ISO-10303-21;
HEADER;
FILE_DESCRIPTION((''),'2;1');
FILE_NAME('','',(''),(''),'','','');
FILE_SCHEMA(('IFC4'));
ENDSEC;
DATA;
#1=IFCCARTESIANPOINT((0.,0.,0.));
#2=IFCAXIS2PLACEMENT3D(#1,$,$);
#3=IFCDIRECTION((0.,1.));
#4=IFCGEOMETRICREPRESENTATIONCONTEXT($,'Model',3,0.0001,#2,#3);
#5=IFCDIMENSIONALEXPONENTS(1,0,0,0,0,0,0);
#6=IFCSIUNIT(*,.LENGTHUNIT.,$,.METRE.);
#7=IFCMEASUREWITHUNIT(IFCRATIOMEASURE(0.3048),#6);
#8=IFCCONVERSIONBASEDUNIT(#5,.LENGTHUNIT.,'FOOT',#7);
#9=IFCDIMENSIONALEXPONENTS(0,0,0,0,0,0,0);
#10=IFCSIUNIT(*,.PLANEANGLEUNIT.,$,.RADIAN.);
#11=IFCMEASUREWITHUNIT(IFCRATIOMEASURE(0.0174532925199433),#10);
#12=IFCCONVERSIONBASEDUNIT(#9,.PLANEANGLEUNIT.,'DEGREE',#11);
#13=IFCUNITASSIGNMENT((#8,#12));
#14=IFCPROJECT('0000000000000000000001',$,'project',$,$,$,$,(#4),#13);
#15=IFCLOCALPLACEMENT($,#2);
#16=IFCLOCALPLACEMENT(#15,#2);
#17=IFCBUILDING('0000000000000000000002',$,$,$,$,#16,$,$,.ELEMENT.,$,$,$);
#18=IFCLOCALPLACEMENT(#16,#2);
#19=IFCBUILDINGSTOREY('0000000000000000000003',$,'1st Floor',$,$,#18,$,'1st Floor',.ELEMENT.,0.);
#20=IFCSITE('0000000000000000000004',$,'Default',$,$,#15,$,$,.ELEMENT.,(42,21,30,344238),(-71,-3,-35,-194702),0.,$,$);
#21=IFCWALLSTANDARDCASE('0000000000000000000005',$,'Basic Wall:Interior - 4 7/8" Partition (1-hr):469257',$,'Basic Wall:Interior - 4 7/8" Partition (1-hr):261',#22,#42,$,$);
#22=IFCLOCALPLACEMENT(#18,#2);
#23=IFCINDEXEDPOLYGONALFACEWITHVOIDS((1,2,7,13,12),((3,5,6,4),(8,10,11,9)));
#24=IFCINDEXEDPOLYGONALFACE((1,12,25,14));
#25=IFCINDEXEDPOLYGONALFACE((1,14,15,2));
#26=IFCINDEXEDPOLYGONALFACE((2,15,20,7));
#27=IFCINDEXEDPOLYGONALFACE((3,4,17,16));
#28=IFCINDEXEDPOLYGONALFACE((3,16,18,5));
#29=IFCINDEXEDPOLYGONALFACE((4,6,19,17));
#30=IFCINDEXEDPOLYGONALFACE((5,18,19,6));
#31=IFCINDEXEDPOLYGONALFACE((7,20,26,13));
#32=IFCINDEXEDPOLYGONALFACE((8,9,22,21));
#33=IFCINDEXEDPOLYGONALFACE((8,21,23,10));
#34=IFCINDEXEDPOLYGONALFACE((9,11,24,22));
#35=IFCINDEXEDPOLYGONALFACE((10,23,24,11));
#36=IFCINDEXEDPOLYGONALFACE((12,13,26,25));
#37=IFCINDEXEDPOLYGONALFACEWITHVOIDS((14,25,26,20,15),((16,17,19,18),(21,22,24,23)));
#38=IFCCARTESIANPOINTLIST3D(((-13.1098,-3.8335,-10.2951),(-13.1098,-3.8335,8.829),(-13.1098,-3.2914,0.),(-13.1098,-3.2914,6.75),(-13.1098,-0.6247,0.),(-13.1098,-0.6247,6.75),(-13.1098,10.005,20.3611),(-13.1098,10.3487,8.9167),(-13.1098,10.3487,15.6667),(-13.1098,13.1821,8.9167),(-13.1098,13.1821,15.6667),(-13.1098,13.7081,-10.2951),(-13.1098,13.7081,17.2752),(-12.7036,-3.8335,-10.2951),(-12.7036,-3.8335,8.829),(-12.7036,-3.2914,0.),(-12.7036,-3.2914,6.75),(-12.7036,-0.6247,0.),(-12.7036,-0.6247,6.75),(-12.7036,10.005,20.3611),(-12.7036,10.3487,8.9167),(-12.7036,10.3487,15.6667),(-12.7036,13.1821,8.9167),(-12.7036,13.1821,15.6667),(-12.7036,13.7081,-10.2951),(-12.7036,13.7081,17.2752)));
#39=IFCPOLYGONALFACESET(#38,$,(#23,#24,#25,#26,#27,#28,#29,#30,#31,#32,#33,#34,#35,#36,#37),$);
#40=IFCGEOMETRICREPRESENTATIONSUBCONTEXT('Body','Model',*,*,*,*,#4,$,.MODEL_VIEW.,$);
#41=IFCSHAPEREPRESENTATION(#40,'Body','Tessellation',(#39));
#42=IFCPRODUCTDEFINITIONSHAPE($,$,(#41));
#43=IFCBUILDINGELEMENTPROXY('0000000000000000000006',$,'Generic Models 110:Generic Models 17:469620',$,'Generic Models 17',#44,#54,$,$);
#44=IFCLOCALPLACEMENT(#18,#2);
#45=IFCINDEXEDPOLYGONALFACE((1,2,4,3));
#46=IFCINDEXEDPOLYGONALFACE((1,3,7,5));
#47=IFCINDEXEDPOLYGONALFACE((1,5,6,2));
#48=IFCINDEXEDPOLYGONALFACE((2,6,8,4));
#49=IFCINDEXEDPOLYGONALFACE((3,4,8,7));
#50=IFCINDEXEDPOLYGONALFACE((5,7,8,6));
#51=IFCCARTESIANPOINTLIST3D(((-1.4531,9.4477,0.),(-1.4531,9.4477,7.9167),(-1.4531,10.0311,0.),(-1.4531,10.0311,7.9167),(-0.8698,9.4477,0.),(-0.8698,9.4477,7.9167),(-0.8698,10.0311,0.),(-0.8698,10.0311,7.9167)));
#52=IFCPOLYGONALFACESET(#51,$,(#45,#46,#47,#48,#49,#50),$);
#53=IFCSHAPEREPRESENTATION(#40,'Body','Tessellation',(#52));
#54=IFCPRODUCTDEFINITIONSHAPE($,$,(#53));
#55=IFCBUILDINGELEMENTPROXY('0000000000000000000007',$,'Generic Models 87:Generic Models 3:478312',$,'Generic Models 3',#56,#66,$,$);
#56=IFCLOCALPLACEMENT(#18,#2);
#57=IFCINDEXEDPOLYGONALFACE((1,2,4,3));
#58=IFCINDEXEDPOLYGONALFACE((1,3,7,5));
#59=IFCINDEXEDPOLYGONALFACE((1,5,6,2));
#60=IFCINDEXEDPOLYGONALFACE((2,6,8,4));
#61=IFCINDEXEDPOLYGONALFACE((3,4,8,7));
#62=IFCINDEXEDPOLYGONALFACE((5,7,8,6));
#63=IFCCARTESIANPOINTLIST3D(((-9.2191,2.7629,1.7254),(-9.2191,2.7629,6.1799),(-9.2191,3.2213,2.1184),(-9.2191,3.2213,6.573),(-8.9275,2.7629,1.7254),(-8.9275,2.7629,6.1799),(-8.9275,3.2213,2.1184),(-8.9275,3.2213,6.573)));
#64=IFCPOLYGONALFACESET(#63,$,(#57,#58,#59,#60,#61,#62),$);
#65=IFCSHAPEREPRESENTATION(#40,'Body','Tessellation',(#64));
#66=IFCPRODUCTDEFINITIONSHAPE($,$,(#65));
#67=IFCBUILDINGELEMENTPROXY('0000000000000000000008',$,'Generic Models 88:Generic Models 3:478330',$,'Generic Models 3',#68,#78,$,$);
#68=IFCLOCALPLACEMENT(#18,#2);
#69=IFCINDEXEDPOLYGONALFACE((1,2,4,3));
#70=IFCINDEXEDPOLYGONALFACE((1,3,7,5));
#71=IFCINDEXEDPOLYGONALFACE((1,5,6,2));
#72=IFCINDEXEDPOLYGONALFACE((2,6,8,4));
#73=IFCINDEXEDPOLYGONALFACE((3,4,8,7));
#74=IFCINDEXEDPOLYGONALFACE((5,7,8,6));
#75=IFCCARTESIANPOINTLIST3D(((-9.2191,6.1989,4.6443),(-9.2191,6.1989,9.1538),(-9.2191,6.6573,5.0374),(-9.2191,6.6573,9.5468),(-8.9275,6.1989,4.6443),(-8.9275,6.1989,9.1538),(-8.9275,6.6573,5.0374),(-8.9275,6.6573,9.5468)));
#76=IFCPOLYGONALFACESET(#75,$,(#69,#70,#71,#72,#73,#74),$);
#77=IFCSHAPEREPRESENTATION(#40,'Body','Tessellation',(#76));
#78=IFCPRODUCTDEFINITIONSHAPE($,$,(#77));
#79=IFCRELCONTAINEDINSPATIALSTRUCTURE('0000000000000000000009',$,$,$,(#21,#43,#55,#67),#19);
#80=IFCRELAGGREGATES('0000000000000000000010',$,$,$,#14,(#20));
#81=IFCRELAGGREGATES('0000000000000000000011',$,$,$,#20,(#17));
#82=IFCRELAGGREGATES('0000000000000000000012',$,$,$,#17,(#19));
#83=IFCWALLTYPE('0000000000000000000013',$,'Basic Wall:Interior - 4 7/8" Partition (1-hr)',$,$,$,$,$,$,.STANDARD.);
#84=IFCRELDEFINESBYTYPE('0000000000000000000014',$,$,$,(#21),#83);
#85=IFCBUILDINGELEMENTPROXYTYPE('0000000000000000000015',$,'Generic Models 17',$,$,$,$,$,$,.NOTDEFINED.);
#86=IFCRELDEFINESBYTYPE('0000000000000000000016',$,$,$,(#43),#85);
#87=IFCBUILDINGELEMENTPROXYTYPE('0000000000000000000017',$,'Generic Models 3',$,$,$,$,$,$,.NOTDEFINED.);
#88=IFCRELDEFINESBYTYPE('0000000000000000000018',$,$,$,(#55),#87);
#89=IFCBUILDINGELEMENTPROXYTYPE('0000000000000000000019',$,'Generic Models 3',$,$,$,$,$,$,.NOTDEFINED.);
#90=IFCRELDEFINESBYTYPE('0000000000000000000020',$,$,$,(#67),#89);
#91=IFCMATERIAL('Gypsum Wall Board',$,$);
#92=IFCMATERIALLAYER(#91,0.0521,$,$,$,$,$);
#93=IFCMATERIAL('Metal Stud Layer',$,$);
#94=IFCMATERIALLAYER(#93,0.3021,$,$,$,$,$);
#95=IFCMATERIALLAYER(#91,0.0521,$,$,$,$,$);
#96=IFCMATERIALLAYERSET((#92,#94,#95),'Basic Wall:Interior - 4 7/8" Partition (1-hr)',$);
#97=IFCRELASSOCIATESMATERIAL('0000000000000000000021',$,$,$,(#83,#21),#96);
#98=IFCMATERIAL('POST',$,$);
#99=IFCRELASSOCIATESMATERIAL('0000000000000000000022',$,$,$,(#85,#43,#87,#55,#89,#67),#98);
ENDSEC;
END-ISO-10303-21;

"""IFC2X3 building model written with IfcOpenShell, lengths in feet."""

from ifc_helpers import new_model, entity, si_unit, converted_unit, direction, frame, frame_2d, origin, place, context, subcontext, project, spatial, polyline, rectangle, outline, extrude, clip, bounded_halfspace, source, transform, mapped, material, layer, layer_set, layer_usage, type_object, type_shapes, element, save


model = new_model("IFC2X3")

# Units and contexts
model_context = context("Model", 3, precision=0.0001, world=origin(), true_north=direction((0.0, 1.0)))
body_context = subcontext(model_context, "Body", "Model", "MODEL_VIEW")
ifc_project = project(units=[converted_unit("LENGTHUNIT", "FOOT", entity("IfcRatioMeasure", 0.3048), si_unit("LENGTHUNIT", "METRE"), dimensions=[1, 0, 0, 0, 0, 0, 0]), converted_unit("PLANEANGLEUNIT", "DEGREE", entity("IfcRatioMeasure", 0.0174532925199433), si_unit("PLANEANGLEUNIT", "RADIAN"), dimensions=[0, 0, 0, 0, 0, 0, 0])], contexts=[model_context])

# Site, building, storey
site_placement = place(None, origin())
site = spatial("IfcSite", under=ifc_project, at=site_placement, Name="Default", CompositionType="ELEMENT", RefLatitude=(42, 21, 30, 344238), RefLongitude=(-71, -3, -35, -194702), RefElevation=0.0)
building_placement = place(site_placement, origin())
building = spatial("IfcBuilding", under=site, at=building_placement, CompositionType="ELEMENT")
storey_placement = place(building_placement, origin())
storey = spatial("IfcBuildingStorey", under=building, at=storey_placement, Name="1st Floor", LongName="1st Floor", CompositionType="ELEMENT", Elevation=0.0)

# Wall, openings
ifc_material_1 = material(Name="Gypsum Wall Board")
ifc_layer_1 = layer(ifc_material_1, 0.0521)
ifc_material_2 = material(Name="Metal Stud Layer")
ifc_layer_2 = layer(ifc_material_2, 0.3021)
ifc_layer_3 = layer(ifc_material_1, 0.0521)
ifc_layer_set_1 = layer_set([ifc_layer_1, ifc_layer_2, ifc_layer_3], Name="Basic Wall:Interior - 4 7/8\" Partition (1-hr)")
ifc_layer_usage_1 = layer_usage(ifc_layer_set_1, "AXIS2", "NEGATIVE", 0.2031)
wall_type = type_object("IfcWallType", Name="Basic Wall:Interior - 4 7/8\" Partition (1-hr)", PredefinedType="STANDARD", material=ifc_layer_set_1)
wall_placement = place(storey_placement, frame((-12.9067, -3.8335, -10.2951), z_axis=(0.0, 0.0, 1.0), x_axis=(0.0, 1.0, 0.0)))
wall = element("IfcWallStandardCase", 1, at=wall_placement, inside=storey, type_object=wall_type, material=ifc_layer_usage_1, Name="Basic Wall:Interior - 4 7/8\" Partition (1-hr):469257", ObjectType="Basic Wall:Interior - 4 7/8\" Partition (1-hr):261", context=body_context, shape_type="Clipping", body=[
    clip(clip(extrude(rectangle(XDim=17.5416, YDim=0.4062, at=frame_2d((8.7708, 0.0), x_axis=(-1.0, 0.0))), origin(), (0.0, 0.0, 1.0), 30.6562), bounded_halfspace(frame((13.8385, -0.2031, 30.6562), z_axis=(0.640184, 0.0, 0.768221), x_axis=(0.0, 1.0, 0.0)), False, frame((13.8385, -0.2031, 30.6562)), polyline([(0.0, 0.0), (3.2969, 0.0), (3.7031, 0.0), (3.7031, 0.4063), (0.0, 0.4062), (0.0, 0.0)]))), bounded_halfspace(frame((0.0, -0.2031, 19.1241), z_axis=(-0.640184, 0.0, 0.768221), x_axis=(0.0, -1.0, 0.0)), False, frame((0.0, -0.2031, 19.1241)), polyline([(0.0, 0.0), (0.4062, 0.0), (13.8385, 0.0), (13.8385, 0.4062), (0.0, 0.4062), (0.0, 0.0)]))),
])
opening_1_placement = place(wall_placement, frame((3.2088, 0.2031, 10.2951)))
element("IfcOpeningElement", 2, at=opening_1_placement, cuts=wall, ObjectType="Opening", context=body_context, shape_type="SweptSolid", body=[
    extrude(rectangle(XDim=6.75, YDim=2.6667, at=frame_2d((3.375, 1.3333), x_axis=(1.0, 0.0))), frame((0.0, 0.0, 0.0), z_axis=(0.0, -1.0, 0.0), x_axis=(0.0, 0.0, 1.0)), (0.0, 0.0, 1.0), 0.4062),
])
opening_2_placement = place(wall_placement, frame((14.1822, -0.2031, 19.2117)))
element("IfcOpeningElement", 3, at=opening_2_placement, cuts=wall, ObjectType="Opening", context=body_context, shape_type="SweptSolid", body=[
    extrude(rectangle(XDim=6.75, YDim=2.8333, at=frame_2d((3.375, 1.4167), x_axis=(1.0, 0.0))), frame((0.0, 0.0, 0.0), z_axis=(0.0, 1.0, 0.0), x_axis=(0.0, 0.0, 1.0)), (0.0, 0.0, 1.0), 0.4062),
])

# Building element proxies
ifc_material_3 = material(Name="POST")
building_element_proxy_type_1 = type_object("IfcBuildingElementProxyType", Name="Generic Models 17", PredefinedType="NOTDEFINED", material=ifc_material_3)
shared_shape_1 = source(origin(), body_context, "Body", "SweptSolid", [
    extrude(rectangle(XDim=0.5834, YDim=0.5833, at=frame_2d((0.0, 0.0), x_axis=(1.0, 0.0))), frame((-1.1615, 9.7394, 0.0), z_axis=(0.0, 0.0, 1.0), x_axis=(0.0, 1.0, 0.0)), (0.0, 0.0, 1.0), 7.9167),
])
type_shapes(building_element_proxy_type_1, [shared_shape_1])
proxy_1_placement = place(storey_placement, origin())
element("IfcBuildingElementProxy", 4, at=proxy_1_placement, inside=storey, type_object=building_element_proxy_type_1, material=ifc_material_3, Name="Generic Models 110:Generic Models 17:469620", ObjectType="Generic Models 17", context=body_context, shape_type="MappedRepresentation", body=[
    mapped(shared_shape_1, transform((0.0, 0.0, 0.0), scale=1.0)),
])
building_element_proxy_type_2 = type_object("IfcBuildingElementProxyType", Name="Generic Models 3", PredefinedType="NOTDEFINED", material=ifc_material_3)
shared_shape_2 = source(origin(), body_context, "Body", "SweptSolid", [
    extrude(outline(polyline([(-1.7517, -1.6908), (-1.148, -1.6908), (1.7517, 1.6908), (1.148, 1.6908), (-1.7517, -1.6908)])), frame((-9.2191, 2.9921, 4.1492), z_axis=(1.0, 0.0, 0.0), x_axis=(0.0, -0.759118, -0.650953)), (0.0, 0.0, 1.0), 0.2917),
])
type_shapes(building_element_proxy_type_2, [shared_shape_2])
proxy_2_placement = place(storey_placement, origin())
element("IfcBuildingElementProxy", 5, at=proxy_2_placement, inside=storey, type_object=building_element_proxy_type_2, material=ifc_material_3, Name="Generic Models 87:Generic Models 3:478312", ObjectType="Generic Models 3", context=body_context, shape_type="MappedRepresentation", body=[
    mapped(shared_shape_2, transform((0.0, 0.0, 0.0), scale=1.0)),
])
building_element_proxy_type_3 = type_object("IfcBuildingElementProxyType", Name="Generic Models 3", PredefinedType="NOTDEFINED", material=ifc_material_3)
shared_shape_3 = source(origin(), body_context, "Body", "SweptSolid", [
    extrude(outline(polyline([(-1.7696, -1.7116), (-1.1658, -1.7116), (1.7696, 1.7116), (1.1658, 1.7116), (-1.7696, -1.7116)])), frame((-9.2191, 6.4281, 7.0956), z_axis=(1.0, 0.0, 0.0), x_axis=(0.0, -0.759118, -0.650953)), (0.0, 0.0, 1.0), 0.2917),
])
type_shapes(building_element_proxy_type_3, [shared_shape_3])
proxy_3_placement = place(storey_placement, origin())
element("IfcBuildingElementProxy", 6, at=proxy_3_placement, inside=storey, type_object=building_element_proxy_type_3, material=ifc_material_3, Name="Generic Models 88:Generic Models 3:478330", ObjectType="Generic Models 3", context=body_context, shape_type="MappedRepresentation", body=[
    mapped(shared_shape_3, transform((0.0, 0.0, 0.0), scale=1.0)),
])

save(model, "model.ifc")
